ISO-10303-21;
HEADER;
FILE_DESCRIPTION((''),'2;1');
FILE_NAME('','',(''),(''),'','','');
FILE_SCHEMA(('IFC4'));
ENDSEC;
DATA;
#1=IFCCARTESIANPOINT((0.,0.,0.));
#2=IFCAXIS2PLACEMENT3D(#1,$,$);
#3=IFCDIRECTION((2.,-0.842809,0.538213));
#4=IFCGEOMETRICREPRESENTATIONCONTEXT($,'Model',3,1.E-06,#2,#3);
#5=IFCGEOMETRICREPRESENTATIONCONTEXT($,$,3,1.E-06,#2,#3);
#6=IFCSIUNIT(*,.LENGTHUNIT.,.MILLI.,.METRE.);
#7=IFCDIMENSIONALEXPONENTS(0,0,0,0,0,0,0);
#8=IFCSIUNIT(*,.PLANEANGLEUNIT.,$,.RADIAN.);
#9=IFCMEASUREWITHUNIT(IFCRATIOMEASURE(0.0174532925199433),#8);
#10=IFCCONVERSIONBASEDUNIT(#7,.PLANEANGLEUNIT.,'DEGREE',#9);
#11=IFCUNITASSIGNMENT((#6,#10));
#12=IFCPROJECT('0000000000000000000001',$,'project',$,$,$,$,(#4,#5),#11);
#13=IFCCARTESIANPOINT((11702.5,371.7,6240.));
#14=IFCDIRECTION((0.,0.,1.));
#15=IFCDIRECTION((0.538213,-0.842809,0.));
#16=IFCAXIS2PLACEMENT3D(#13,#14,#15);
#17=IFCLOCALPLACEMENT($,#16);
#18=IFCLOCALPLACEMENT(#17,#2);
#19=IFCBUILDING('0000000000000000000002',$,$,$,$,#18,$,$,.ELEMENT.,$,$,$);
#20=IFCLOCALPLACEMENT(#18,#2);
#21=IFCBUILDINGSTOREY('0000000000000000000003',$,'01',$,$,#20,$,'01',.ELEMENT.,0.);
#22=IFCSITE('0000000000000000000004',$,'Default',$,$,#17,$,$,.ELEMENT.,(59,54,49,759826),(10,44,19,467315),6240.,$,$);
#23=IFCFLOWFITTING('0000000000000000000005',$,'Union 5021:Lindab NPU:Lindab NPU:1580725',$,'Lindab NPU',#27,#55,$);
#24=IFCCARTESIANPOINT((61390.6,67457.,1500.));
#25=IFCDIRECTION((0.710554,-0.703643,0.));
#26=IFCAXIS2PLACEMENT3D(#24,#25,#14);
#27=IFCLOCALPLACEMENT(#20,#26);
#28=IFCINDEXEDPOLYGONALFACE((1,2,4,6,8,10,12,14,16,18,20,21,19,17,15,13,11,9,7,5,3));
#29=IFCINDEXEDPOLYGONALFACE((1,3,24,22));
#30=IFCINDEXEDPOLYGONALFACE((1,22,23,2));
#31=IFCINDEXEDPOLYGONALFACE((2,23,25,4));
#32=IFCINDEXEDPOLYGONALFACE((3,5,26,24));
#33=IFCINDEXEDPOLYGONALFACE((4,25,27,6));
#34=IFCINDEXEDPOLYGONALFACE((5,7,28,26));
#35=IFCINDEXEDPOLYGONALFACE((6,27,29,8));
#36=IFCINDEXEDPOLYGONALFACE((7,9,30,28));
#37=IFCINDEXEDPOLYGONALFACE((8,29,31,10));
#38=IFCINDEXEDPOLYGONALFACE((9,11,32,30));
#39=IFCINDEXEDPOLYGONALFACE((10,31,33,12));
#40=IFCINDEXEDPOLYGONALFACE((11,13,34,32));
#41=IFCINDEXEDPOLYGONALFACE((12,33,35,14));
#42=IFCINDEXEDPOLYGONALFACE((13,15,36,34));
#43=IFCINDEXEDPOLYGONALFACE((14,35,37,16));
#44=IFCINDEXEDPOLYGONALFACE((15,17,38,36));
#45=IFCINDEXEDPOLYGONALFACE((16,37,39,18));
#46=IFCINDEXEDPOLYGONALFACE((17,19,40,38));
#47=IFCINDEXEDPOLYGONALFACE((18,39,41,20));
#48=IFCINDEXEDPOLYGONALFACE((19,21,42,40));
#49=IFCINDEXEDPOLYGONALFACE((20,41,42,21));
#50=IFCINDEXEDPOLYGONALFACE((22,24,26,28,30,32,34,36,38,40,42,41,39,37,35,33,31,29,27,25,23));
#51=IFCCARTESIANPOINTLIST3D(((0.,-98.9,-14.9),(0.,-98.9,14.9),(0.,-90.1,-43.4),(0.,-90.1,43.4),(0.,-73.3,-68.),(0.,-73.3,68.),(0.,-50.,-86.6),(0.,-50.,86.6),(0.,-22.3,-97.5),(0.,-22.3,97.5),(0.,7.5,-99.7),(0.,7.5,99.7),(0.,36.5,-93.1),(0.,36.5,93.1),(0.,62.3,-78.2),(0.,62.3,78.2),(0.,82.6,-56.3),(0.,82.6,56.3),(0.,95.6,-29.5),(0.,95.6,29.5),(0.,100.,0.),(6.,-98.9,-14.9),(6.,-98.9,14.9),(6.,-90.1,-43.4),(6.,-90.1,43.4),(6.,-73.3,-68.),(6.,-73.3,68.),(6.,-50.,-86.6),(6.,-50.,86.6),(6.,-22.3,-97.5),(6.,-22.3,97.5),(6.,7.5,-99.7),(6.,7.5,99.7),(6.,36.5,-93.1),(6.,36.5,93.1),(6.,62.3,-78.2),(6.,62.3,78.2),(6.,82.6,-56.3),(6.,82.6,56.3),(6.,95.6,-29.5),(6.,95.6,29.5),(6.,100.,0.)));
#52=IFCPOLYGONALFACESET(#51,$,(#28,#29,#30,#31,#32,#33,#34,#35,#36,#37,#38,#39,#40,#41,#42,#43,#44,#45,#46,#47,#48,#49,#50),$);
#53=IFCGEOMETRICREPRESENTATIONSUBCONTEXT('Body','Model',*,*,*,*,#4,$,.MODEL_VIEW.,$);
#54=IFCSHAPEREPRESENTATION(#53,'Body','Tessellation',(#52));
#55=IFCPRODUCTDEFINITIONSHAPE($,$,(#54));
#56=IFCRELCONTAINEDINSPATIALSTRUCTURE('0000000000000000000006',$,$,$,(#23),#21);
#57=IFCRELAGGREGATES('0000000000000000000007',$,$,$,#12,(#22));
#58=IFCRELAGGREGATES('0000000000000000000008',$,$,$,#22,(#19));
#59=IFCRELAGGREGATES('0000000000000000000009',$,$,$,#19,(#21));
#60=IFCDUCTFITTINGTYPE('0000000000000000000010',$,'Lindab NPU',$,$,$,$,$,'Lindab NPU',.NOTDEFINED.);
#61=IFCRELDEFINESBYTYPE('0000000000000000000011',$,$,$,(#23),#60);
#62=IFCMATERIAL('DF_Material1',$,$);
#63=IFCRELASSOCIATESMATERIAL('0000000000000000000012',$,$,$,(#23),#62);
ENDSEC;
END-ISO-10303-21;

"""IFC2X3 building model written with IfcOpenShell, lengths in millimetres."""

from ifc_helpers import new_model, entity, si_unit, converted_unit, direction, frame, frame_2d, origin, place, context, subcontext, project, spatial, circle, extrude, source, transform, mapped, material, type_object, type_shapes, element, save


model = new_model("IFC2X3")

# Units and contexts
model_context = context("Model", 3, precision=1e-06, world=origin(), true_north=direction((2.0, -0.842809, 0.538213)))
context_of_model = context(None, 3, precision=1e-06, world=origin(), true_north=direction((2.0, -0.842809, 0.538213)))
body_context = subcontext(model_context, "Body", "Model", "MODEL_VIEW")
ifc_project = project(units=[si_unit("LENGTHUNIT", "METRE", prefix="MILLI"), converted_unit("PLANEANGLEUNIT", "DEGREE", entity("IfcRatioMeasure", 0.0174532925199433), si_unit("PLANEANGLEUNIT", "RADIAN"), dimensions=[0, 0, 0, 0, 0, 0, 0])], contexts=[model_context, context_of_model])

# Site, building, storey
site_placement = place(None, frame((11702.5, 371.7, 6240.0), z_axis=(0.0, 0.0, 1.0), x_axis=(0.538213, -0.842809, 0.0)))
site = spatial("IfcSite", under=ifc_project, at=site_placement, Name="Default", CompositionType="ELEMENT", RefLatitude=(59, 54, 49, 759826), RefLongitude=(10, 44, 19, 467315), RefElevation=6240.0)
building_placement = place(site_placement, origin())
building = spatial("IfcBuilding", under=site, at=building_placement, CompositionType="ELEMENT")
storey_placement = place(building_placement, origin())
storey = spatial("IfcBuildingStorey", under=building, at=storey_placement, Name="01", LongName="01", CompositionType="ELEMENT", Elevation=0.0)

# Flow fitting
ifc_material = material(Name="DF_Material1")
duct_fitting_type_1 = type_object("IfcDuctFittingType", Name="Lindab NPU", ElementType="Lindab NPU", PredefinedType="NOTDEFINED")
shared_shape_1 = source(origin(), body_context, "Body", "SweptSolid", [
    extrude(circle(Radius=100.0, at=frame_2d((0.0, 0.0), x_axis=(1.0, 0.0))), frame((0.0, 0.0, 0.0), z_axis=(1.0, 0.0, 0.0), x_axis=(0.0, 1.0, 0.0)), (0.0, 0.0, 1.0), 6.0),
])
type_shapes(duct_fitting_type_1, [shared_shape_1])
for number, where, z_axis, x_axis, name in (
    (1, (61390.6, 67457.0, 1500.0), (0.710554, -0.703643, 0.0), (0.0, 0.0, 1.0), "Union 5021:Lindab NPU:Lindab NPU:1580725"),
):
    element("IfcFlowFitting", number, at=place(storey_placement, frame(where, z_axis=z_axis, x_axis=x_axis)), inside=storey, type_object=duct_fitting_type_1, material=ifc_material, Name=name, ObjectType="Lindab NPU", context=body_context, shape_type="MappedRepresentation", body=[
        mapped(shared_shape_1, transform((0.0, 0.0, 0.0), scale=1.0)),
    ])

save(model, "model.ifc")
